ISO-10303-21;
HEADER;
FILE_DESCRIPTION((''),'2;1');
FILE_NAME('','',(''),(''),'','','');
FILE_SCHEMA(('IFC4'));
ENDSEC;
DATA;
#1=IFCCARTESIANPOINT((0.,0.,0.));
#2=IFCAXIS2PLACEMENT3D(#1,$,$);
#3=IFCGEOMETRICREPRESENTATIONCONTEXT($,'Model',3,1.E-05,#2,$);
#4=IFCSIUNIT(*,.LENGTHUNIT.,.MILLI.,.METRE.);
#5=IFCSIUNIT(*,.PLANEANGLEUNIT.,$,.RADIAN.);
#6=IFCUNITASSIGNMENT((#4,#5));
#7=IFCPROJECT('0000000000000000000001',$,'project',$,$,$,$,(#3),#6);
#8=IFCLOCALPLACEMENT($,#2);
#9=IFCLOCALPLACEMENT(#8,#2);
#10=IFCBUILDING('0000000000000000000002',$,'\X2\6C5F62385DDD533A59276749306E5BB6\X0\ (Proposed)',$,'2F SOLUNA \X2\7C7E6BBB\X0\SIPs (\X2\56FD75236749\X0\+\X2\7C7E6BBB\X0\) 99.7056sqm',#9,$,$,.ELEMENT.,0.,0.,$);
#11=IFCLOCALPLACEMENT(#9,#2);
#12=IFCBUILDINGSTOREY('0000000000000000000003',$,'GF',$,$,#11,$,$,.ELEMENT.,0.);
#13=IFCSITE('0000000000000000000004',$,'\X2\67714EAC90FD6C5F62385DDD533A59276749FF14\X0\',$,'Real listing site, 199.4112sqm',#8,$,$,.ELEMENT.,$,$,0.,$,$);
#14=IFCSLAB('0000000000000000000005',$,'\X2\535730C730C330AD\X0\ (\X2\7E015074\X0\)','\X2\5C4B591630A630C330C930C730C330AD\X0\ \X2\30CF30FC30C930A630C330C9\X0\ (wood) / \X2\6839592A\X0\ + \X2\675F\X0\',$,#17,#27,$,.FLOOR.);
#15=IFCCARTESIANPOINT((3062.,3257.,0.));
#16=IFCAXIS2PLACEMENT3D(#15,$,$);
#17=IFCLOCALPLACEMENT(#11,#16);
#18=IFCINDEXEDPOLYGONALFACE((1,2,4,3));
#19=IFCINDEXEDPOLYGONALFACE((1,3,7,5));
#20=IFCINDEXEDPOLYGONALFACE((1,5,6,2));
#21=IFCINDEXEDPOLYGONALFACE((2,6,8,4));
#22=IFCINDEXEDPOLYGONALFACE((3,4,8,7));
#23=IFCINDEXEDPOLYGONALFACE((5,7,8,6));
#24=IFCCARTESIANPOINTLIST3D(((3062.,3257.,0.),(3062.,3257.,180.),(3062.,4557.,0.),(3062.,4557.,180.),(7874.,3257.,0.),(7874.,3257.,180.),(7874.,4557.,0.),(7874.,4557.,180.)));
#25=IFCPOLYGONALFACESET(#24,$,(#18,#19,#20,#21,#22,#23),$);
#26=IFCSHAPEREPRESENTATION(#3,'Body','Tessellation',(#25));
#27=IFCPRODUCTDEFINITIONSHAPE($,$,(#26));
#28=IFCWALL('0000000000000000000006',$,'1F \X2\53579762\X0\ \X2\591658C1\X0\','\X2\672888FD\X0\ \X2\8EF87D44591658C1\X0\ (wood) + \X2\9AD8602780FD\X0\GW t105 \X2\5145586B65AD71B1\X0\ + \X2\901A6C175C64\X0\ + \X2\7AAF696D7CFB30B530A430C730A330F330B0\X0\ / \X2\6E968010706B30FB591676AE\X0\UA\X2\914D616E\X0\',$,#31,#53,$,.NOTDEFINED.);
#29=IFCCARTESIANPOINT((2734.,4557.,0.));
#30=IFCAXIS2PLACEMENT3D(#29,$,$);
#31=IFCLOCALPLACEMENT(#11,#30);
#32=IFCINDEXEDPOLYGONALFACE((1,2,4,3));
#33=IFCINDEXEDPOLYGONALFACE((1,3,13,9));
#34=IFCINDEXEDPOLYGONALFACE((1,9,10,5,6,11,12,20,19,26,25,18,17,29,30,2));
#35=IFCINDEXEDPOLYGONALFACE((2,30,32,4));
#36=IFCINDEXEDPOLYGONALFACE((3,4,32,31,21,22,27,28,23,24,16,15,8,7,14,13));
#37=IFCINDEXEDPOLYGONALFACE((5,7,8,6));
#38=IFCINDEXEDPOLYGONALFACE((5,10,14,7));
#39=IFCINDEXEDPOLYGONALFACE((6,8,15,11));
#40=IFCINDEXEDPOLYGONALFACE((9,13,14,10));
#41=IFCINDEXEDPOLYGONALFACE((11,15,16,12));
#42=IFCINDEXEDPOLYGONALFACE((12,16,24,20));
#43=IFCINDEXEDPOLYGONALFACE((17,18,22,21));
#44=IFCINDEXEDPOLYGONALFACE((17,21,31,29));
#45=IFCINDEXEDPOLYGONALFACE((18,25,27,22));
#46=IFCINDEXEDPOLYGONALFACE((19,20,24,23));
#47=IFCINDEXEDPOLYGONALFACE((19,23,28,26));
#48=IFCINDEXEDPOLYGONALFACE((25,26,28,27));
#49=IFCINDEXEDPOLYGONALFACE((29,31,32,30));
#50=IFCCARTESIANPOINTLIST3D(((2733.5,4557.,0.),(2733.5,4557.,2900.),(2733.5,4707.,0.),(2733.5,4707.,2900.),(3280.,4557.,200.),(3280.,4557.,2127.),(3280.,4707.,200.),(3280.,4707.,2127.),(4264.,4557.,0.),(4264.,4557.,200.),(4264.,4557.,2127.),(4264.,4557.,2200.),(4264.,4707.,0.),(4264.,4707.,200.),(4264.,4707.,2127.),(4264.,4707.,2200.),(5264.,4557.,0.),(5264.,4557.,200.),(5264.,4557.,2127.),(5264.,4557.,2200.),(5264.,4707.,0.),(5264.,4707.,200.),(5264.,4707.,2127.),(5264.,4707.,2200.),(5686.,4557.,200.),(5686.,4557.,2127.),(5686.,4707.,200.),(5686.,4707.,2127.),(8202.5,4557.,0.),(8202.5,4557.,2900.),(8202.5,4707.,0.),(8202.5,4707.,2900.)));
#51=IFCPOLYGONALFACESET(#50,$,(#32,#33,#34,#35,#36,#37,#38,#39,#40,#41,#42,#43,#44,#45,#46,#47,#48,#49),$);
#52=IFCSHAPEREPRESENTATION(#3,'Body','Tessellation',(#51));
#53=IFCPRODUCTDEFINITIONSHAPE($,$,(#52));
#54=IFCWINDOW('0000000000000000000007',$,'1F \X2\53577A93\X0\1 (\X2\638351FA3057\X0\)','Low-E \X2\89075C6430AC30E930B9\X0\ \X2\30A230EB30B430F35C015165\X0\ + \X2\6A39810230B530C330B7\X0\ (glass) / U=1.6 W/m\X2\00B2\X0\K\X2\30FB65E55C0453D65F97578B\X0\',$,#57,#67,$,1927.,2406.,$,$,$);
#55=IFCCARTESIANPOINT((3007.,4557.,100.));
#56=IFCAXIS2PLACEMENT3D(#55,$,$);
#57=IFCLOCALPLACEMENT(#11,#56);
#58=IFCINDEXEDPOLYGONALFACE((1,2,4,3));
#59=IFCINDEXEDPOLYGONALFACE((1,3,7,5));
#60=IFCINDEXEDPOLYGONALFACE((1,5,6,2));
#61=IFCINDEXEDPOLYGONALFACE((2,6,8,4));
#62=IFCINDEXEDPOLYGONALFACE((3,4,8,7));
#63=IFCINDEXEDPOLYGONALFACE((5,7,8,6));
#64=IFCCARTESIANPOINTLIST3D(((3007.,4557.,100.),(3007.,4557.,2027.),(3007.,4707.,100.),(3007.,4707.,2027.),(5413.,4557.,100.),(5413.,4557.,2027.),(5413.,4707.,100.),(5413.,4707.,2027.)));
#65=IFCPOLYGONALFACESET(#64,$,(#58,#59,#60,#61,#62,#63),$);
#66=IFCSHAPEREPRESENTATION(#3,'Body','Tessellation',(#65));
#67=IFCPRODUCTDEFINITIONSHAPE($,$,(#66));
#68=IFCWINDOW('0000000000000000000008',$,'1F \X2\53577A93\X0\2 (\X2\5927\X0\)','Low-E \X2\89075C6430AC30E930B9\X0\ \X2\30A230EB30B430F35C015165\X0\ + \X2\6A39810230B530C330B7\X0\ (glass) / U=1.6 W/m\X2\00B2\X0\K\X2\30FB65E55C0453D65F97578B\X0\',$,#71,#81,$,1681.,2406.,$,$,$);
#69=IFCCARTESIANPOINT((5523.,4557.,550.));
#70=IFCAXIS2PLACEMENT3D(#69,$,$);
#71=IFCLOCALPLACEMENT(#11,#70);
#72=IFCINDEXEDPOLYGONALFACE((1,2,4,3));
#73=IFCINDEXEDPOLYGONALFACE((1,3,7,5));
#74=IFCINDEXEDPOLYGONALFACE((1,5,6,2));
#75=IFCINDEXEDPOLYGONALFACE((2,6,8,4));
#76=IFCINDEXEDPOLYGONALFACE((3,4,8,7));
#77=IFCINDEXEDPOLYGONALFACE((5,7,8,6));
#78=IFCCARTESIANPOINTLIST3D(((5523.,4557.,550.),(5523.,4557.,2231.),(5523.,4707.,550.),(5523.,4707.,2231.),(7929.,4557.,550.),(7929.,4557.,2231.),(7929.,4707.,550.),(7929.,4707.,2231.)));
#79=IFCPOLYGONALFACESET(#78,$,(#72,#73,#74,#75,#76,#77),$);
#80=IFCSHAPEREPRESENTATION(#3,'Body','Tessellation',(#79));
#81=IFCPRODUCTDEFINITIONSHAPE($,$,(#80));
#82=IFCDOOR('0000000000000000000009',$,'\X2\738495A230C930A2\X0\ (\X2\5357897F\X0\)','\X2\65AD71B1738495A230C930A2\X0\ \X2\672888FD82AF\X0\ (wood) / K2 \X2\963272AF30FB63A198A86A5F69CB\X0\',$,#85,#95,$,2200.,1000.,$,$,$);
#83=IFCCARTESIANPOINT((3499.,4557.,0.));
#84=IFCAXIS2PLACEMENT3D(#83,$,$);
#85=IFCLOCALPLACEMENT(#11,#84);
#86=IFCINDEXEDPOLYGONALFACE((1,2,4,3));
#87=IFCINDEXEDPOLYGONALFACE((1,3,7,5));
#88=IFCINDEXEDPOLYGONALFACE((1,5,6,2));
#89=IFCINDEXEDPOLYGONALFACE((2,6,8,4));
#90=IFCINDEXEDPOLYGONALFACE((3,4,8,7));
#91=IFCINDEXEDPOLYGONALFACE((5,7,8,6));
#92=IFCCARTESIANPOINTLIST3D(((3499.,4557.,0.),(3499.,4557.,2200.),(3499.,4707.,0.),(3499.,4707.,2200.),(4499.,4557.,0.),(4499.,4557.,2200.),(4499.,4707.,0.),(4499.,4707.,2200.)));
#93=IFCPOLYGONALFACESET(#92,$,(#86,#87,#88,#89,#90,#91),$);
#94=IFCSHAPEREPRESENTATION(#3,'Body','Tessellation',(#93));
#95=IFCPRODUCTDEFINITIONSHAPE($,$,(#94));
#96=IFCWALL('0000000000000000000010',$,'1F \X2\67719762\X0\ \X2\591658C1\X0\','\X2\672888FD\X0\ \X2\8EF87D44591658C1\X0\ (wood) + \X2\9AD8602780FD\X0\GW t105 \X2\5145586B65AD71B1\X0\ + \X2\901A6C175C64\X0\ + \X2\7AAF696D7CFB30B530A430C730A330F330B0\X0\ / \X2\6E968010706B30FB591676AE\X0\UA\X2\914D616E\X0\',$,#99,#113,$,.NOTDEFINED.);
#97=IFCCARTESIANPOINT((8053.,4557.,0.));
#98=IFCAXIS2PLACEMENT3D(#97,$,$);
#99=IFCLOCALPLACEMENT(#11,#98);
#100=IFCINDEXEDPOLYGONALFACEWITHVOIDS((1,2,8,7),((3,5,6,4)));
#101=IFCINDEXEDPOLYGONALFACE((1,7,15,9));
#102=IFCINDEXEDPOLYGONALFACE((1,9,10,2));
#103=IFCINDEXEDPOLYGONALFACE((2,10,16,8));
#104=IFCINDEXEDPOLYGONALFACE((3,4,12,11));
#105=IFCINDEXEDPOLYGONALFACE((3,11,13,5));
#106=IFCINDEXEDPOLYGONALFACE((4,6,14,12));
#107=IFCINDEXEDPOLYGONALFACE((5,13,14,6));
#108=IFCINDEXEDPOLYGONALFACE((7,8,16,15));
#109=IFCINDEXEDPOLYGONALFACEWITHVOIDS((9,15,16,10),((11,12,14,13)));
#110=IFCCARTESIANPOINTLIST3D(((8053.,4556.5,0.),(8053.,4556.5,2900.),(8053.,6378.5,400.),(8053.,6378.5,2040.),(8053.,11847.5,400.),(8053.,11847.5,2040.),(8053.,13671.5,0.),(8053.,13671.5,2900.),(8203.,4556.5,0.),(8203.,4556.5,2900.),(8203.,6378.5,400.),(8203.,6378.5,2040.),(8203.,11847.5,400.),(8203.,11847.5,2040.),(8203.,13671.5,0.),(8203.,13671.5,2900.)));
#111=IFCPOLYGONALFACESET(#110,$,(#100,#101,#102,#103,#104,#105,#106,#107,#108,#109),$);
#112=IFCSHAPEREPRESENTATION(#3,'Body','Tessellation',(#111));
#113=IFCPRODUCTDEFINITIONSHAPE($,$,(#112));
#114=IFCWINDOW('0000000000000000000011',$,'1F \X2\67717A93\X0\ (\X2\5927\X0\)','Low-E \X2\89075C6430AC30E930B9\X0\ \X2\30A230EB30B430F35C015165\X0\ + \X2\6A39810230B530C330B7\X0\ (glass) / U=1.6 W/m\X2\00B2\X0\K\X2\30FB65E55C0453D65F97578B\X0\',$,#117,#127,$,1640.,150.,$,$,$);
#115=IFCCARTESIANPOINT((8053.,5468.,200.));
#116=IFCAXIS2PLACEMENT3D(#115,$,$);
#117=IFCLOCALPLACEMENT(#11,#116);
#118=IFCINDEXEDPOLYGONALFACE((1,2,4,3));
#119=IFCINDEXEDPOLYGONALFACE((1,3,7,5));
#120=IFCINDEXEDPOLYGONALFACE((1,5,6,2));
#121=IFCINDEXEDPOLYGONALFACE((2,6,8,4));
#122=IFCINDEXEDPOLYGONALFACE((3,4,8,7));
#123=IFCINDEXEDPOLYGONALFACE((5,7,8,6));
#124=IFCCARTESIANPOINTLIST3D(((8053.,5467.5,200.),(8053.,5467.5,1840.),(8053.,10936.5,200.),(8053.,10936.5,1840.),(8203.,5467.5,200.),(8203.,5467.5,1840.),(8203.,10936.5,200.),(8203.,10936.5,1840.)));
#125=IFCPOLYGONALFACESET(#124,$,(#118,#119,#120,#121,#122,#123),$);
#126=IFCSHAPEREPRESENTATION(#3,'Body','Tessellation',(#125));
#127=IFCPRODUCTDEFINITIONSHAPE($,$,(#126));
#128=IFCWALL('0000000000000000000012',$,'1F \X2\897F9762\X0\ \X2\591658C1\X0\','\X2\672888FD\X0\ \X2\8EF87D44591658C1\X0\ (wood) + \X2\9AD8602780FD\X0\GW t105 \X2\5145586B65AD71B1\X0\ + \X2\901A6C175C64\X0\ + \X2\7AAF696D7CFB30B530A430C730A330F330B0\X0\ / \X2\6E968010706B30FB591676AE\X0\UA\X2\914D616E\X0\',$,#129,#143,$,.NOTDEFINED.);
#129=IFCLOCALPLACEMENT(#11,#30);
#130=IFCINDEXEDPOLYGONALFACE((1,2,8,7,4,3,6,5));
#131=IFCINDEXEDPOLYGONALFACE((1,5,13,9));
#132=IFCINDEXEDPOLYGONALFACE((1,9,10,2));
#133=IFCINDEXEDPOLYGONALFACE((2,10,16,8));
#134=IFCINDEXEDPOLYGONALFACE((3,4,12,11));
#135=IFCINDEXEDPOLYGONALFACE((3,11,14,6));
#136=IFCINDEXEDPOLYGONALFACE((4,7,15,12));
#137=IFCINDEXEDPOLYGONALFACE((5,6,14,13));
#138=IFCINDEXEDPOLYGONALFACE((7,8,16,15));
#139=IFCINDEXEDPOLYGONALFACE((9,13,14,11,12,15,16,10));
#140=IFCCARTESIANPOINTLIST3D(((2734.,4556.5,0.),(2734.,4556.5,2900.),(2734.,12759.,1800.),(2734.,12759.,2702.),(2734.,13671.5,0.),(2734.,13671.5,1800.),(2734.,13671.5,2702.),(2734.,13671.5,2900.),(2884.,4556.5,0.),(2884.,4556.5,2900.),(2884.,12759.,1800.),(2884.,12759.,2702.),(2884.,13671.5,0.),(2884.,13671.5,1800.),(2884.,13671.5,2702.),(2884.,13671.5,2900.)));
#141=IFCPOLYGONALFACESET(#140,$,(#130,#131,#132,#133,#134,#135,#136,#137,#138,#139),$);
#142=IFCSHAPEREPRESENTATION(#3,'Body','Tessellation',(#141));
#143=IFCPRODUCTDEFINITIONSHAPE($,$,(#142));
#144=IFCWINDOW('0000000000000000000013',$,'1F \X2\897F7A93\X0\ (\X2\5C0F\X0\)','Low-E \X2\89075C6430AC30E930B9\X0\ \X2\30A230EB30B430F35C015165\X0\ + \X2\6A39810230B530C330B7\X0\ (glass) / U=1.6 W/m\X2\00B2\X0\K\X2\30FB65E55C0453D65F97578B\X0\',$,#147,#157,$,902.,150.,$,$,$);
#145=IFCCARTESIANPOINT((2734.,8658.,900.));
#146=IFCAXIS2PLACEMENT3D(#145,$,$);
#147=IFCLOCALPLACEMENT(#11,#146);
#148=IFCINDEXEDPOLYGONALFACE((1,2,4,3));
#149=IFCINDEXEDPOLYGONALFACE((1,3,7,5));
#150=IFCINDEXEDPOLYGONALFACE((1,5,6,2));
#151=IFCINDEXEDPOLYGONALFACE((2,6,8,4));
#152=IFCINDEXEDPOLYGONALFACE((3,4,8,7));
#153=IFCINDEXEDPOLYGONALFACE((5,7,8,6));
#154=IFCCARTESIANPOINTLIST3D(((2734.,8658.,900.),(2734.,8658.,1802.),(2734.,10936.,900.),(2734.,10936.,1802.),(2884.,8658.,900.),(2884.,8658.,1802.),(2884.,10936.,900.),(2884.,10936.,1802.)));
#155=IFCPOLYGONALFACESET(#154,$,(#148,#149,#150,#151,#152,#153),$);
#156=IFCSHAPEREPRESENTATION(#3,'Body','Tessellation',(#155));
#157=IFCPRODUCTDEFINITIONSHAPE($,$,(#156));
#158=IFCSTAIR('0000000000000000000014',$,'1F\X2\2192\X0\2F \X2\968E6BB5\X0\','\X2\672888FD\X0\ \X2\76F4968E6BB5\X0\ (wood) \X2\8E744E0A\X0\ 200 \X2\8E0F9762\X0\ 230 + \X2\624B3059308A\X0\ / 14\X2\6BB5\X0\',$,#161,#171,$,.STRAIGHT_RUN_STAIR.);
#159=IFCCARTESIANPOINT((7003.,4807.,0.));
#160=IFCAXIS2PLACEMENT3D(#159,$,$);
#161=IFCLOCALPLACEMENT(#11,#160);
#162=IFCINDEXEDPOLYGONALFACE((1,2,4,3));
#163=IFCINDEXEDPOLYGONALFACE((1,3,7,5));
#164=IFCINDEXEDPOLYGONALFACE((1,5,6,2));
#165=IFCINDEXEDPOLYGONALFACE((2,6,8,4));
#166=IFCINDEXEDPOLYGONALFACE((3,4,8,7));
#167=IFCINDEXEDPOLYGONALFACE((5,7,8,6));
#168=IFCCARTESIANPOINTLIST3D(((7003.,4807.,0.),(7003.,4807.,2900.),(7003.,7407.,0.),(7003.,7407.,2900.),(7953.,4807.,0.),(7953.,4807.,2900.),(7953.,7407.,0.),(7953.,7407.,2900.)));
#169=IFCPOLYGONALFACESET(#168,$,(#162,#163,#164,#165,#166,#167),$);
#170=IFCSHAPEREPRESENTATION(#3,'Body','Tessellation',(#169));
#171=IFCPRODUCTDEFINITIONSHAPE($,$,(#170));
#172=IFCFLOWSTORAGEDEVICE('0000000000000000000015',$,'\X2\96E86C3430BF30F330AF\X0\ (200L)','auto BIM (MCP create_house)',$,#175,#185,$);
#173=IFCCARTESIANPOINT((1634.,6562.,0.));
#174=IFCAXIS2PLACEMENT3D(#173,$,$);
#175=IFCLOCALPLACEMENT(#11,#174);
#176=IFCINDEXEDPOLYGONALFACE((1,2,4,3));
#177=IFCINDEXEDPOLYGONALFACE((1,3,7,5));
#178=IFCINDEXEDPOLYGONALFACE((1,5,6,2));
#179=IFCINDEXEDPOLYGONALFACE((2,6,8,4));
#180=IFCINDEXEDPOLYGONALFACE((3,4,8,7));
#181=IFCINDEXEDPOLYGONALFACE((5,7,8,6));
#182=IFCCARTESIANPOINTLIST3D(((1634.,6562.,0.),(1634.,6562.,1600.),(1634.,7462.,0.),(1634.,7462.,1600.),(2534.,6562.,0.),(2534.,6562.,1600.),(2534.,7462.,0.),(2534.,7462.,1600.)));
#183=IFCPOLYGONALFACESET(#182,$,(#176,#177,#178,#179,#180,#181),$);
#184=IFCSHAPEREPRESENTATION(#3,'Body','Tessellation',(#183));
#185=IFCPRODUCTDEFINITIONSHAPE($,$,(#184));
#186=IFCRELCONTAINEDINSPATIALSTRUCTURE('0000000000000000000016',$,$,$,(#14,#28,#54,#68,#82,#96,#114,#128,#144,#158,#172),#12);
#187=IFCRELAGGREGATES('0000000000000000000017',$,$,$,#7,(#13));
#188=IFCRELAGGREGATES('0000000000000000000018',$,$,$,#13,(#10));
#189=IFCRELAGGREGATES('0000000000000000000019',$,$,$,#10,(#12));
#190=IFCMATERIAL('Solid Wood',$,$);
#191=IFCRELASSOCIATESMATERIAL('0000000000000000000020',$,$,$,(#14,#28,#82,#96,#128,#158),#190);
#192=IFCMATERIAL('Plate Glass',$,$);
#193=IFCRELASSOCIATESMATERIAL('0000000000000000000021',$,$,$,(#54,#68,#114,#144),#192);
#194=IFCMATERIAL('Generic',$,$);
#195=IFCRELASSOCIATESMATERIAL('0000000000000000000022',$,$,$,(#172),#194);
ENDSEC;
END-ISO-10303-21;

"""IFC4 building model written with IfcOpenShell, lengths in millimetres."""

from ifc_helpers import new_model, si_unit, frame, frame_2d, origin, place, context, project, spatial, rectangle, extrude, material, element, fill, save


model = new_model("IFC4")

# Units and contexts
model_context = context("Model", 3, precision=1e-05, world=origin())
ifc_project = project(units=[si_unit("LENGTHUNIT", "METRE", prefix="MILLI"), si_unit("PLANEANGLEUNIT", "RADIAN")], contexts=[model_context])

# Site, building, storey
site_placement = place(None, origin())
site = spatial("IfcSite", under=ifc_project, at=site_placement, Name="東京都江戸川区大杉４", ObjectType="Real listing site, 199.4112sqm", CompositionType="ELEMENT", RefElevation=0.0)
building_placement = place(site_placement, origin())
building = spatial("IfcBuilding", under=site, at=building_placement, Name="江戸川区大杉の家 (Proposed)", ObjectType="2F SOLUNA 籾殻SIPs (国産杉+籾殻) 99.7056sqm", CompositionType="ELEMENT", ElevationOfRefHeight=0.0, ElevationOfTerrain=0.0)
storey_placement = place(building_placement, origin())
storey = spatial("IfcBuildingStorey", under=building, at=storey_placement, Name="GF", CompositionType="ELEMENT", Elevation=0.0)

# Slab
ifc_material_1 = material(Name="Solid Wood")
slab_1_placement = place(storey_placement, frame((3062.0, 3257.0, 0.0)))
element("IfcSlab", 1, at=slab_1_placement, inside=storey, material=ifc_material_1, Name="南デッキ (縁側)", Description="屋外ウッドデッキ ハードウッド (wood) / 根太 + 束", PredefinedType="FLOOR", context=model_context, shape_type="SweptSolid", body=[
    extrude(rectangle(XDim=4812.0, YDim=1300.0, at=frame_2d((2406.0, 650.0))), frame((3062.0, 3257.0, 0.0)), (0.0, 0.0, 1.0), 180.0),
])

# Wall, openings, windows, door
wall_1_placement = place(storey_placement, frame((2734.0, 4557.0, 0.0)))
wall_1 = element("IfcWall", 2, at=wall_1_placement, inside=storey, material=ifc_material_1, Name="1F 南面 外壁", Description="木製 軸組外壁 (wood) + 高性能GW t105 充填断熱 + 通気層 + 窯業系サイディング / 準耐火・外皮UA配慮", PredefinedType="NOTDEFINED", context=model_context, shape_type="SweptSolid", body=[
    extrude(rectangle(XDim=5469.0, YDim=150.0, at=frame_2d((2734.0, 75.0))), frame((2734.0, 4557.0, 0.0)), (0.0, 0.0, 1.0), 2900.0),
])
opening_1_placement = place(storey_placement, frame((3007.0, 4557.0, 100.0)))
opening_1 = element("IfcOpeningElement", 3, at=opening_1_placement, cuts=wall_1, PredefinedType="NOTDEFINED", context=model_context, shape_type="SweptSolid", body=[
    extrude(rectangle(XDim=2406.0, YDim=150.0, at=frame_2d((1203.0, 75.0))), frame((3007.0, 4557.0, 100.0)), (0.0, 0.0, 1.0), 1927.0),
])
opening_2_placement = place(storey_placement, frame((5523.0, 4557.0, 550.0)))
opening_2 = element("IfcOpeningElement", 4, at=opening_2_placement, cuts=wall_1, PredefinedType="NOTDEFINED", context=model_context, shape_type="SweptSolid", body=[
    extrude(rectangle(XDim=2406.0, YDim=150.0, at=frame_2d((1203.0, 75.0))), frame((5523.0, 4557.0, 550.0)), (0.0, 0.0, 1.0), 1681.0),
])
opening_3_placement = place(storey_placement, frame((3499.0, 4557.0, 0.0)))
opening_3 = element("IfcOpeningElement", 5, at=opening_3_placement, cuts=wall_1, PredefinedType="NOTDEFINED", context=model_context, shape_type="SweptSolid", body=[
    extrude(rectangle(XDim=1000.0, YDim=150.0, at=frame_2d((500.0, 75.0))), frame((3499.0, 4557.0, 0.0)), (0.0, 0.0, 1.0), 2200.0),
])
ifc_material_2 = material(Name="Plate Glass")
window_1_placement = place(storey_placement, frame((3007.0, 4557.0, 100.0)))
window_1 = element("IfcWindow", 6, at=window_1_placement, inside=storey, material=ifc_material_2, Name="1F 南窓1 (掃出し)", Description="Low-E 複層ガラス アルゴン封入 + 樹脂サッシ (glass) / U=1.6 W/m²K・日射取得型", OverallHeight=1927.0, OverallWidth=2406.0, context=model_context, shape_type="SweptSolid", body=[
    extrude(rectangle(XDim=2406.0, YDim=150.0, at=frame_2d((1203.0, 75.0))), frame((3007.0, 4557.0, 100.0)), (0.0, 0.0, 1.0), 1927.0),
])
fill(opening_1, window_1)
window_2_placement = place(storey_placement, frame((5523.0, 4557.0, 550.0)))
window_2 = element("IfcWindow", 7, at=window_2_placement, inside=storey, material=ifc_material_2, Name="1F 南窓2 (大)", Description="Low-E 複層ガラス アルゴン封入 + 樹脂サッシ (glass) / U=1.6 W/m²K・日射取得型", OverallHeight=1681.0, OverallWidth=2406.0, context=model_context, shape_type="SweptSolid", body=[
    extrude(rectangle(XDim=2406.0, YDim=150.0, at=frame_2d((1203.0, 75.0))), frame((5523.0, 4557.0, 550.0)), (0.0, 0.0, 1.0), 1681.0),
])
fill(opening_2, window_2)
door_placement = place(storey_placement, frame((3499.0, 4557.0, 0.0)))
door = element("IfcDoor", 8, at=door_placement, inside=storey, material=ifc_material_1, Name="玄関ドア (南西)", Description="断熱玄関ドア 木製芯 (wood) / K2 防犯・採風機構", OverallHeight=2200.0, OverallWidth=1000.0, context=model_context, shape_type="SweptSolid", body=[
    extrude(rectangle(XDim=1000.0, YDim=150.0, at=frame_2d((500.0, 75.0))), frame((3499.0, 4557.0, 0.0)), (0.0, 0.0, 1.0), 2200.0),
])
fill(opening_3, door)

# Walls, openings, windows
wall_2_placement = place(storey_placement, frame((8053.0, 4557.0, 0.0)))
wall_2 = element("IfcWall", 9, at=wall_2_placement, inside=storey, material=ifc_material_1, Name="1F 東面 外壁", Description="木製 軸組外壁 (wood) + 高性能GW t105 充填断熱 + 通気層 + 窯業系サイディング / 準耐火・外皮UA配慮", PredefinedType="NOTDEFINED", context=model_context, shape_type="SweptSolid", body=[
    extrude(rectangle(XDim=150.0, YDim=9115.0, at=frame_2d((75.0, 4557.0))), frame((8053.0, 4557.0, 0.0)), (0.0, 0.0, 1.0), 2900.0),
])
opening_4_placement = place(storey_placement, frame((8053.0, 5468.0, 200.0)))
opening_4 = element("IfcOpeningElement", 10, at=opening_4_placement, cuts=wall_2, PredefinedType="NOTDEFINED", context=model_context, shape_type="SweptSolid", body=[
    extrude(rectangle(XDim=150.0, YDim=5469.0, at=frame_2d((75.0, 2734.0))), frame((8053.0, 5468.0, 200.0)), (0.0, 0.0, 1.0), 1640.0),
])
window_3_placement = place(storey_placement, frame((8053.0, 5468.0, 200.0)))
window_3 = element("IfcWindow", 11, at=window_3_placement, inside=storey, material=ifc_material_2, Name="1F 東窓 (大)", Description="Low-E 複層ガラス アルゴン封入 + 樹脂サッシ (glass) / U=1.6 W/m²K・日射取得型", OverallHeight=1640.0, OverallWidth=150.0, context=model_context, shape_type="SweptSolid", body=[
    extrude(rectangle(XDim=150.0, YDim=5469.0, at=frame_2d((75.0, 2734.0))), frame((8053.0, 5468.0, 200.0)), (0.0, 0.0, 1.0), 1640.0),
])
fill(opening_4, window_3)
wall_3_placement = place(storey_placement, frame((2734.0, 4557.0, 0.0)))
wall_3 = element("IfcWall", 12, at=wall_3_placement, inside=storey, material=ifc_material_1, Name="1F 西面 外壁", Description="木製 軸組外壁 (wood) + 高性能GW t105 充填断熱 + 通気層 + 窯業系サイディング / 準耐火・外皮UA配慮", PredefinedType="NOTDEFINED", context=model_context, shape_type="SweptSolid", body=[
    extrude(rectangle(XDim=150.0, YDim=9115.0, at=frame_2d((75.0, 4557.0))), frame((2734.0, 4557.0, 0.0)), (0.0, 0.0, 1.0), 2900.0),
])
opening_5_placement = place(storey_placement, frame((2734.0, 8658.0, 900.0)))
opening_5 = element("IfcOpeningElement", 13, at=opening_5_placement, cuts=wall_3, PredefinedType="NOTDEFINED", context=model_context, shape_type="SweptSolid", body=[
    extrude(rectangle(XDim=150.0, YDim=2278.0, at=frame_2d((75.0, 1139.0))), frame((2734.0, 8658.0, 900.0)), (0.0, 0.0, 1.0), 902.0),
])
window_4_placement = place(storey_placement, frame((2734.0, 8658.0, 900.0)))
window_4 = element("IfcWindow", 14, at=window_4_placement, inside=storey, material=ifc_material_2, Name="1F 西窓 (小)", Description="Low-E 複層ガラス アルゴン封入 + 樹脂サッシ (glass) / U=1.6 W/m²K・日射取得型", OverallHeight=902.0, OverallWidth=150.0, context=model_context, shape_type="SweptSolid", body=[
    extrude(rectangle(XDim=150.0, YDim=2278.0, at=frame_2d((75.0, 1139.0))), frame((2734.0, 8658.0, 900.0)), (0.0, 0.0, 1.0), 902.0),
])
fill(opening_5, window_4)

# Stair
stair_placement = place(storey_placement, frame((7003.0, 4807.0, 0.0)))
element("IfcStair", 15, at=stair_placement, inside=storey, material=ifc_material_1, Name="1F→2F 階段", Description="木製 直階段 (wood) 蹴上 200 踏面 230 + 手すり / 14段", PredefinedType="STRAIGHT_RUN_STAIR", context=model_context, shape_type="SweptSolid", body=[
    extrude(rectangle(XDim=950.0, YDim=2600.0, at=frame_2d((475.0, 1300.0))), frame((7003.0, 4807.0, 0.0)), (0.0, 0.0, 1.0), 2900.0),
])

# Shared definitions
ifc_material_3 = material(Name="Generic")

# Flow storage device
flow_storage_device_placement = place(storey_placement, frame((1634.0, 6562.0, 0.0)))
element("IfcFlowStorageDevice", 16, at=flow_storage_device_placement, inside=storey, material=ifc_material_3, Name="雨水タンク (200L)", Description="auto BIM (MCP create_house)", context=model_context, shape_type="SweptSolid", body=[
    extrude(rectangle(XDim=900.0, YDim=900.0, at=frame_2d((450.0, 450.0))), frame((1634.0, 6562.0, 0.0)), (0.0, 0.0, 1.0), 1600.0),
])

save(model, "model.ifc")
